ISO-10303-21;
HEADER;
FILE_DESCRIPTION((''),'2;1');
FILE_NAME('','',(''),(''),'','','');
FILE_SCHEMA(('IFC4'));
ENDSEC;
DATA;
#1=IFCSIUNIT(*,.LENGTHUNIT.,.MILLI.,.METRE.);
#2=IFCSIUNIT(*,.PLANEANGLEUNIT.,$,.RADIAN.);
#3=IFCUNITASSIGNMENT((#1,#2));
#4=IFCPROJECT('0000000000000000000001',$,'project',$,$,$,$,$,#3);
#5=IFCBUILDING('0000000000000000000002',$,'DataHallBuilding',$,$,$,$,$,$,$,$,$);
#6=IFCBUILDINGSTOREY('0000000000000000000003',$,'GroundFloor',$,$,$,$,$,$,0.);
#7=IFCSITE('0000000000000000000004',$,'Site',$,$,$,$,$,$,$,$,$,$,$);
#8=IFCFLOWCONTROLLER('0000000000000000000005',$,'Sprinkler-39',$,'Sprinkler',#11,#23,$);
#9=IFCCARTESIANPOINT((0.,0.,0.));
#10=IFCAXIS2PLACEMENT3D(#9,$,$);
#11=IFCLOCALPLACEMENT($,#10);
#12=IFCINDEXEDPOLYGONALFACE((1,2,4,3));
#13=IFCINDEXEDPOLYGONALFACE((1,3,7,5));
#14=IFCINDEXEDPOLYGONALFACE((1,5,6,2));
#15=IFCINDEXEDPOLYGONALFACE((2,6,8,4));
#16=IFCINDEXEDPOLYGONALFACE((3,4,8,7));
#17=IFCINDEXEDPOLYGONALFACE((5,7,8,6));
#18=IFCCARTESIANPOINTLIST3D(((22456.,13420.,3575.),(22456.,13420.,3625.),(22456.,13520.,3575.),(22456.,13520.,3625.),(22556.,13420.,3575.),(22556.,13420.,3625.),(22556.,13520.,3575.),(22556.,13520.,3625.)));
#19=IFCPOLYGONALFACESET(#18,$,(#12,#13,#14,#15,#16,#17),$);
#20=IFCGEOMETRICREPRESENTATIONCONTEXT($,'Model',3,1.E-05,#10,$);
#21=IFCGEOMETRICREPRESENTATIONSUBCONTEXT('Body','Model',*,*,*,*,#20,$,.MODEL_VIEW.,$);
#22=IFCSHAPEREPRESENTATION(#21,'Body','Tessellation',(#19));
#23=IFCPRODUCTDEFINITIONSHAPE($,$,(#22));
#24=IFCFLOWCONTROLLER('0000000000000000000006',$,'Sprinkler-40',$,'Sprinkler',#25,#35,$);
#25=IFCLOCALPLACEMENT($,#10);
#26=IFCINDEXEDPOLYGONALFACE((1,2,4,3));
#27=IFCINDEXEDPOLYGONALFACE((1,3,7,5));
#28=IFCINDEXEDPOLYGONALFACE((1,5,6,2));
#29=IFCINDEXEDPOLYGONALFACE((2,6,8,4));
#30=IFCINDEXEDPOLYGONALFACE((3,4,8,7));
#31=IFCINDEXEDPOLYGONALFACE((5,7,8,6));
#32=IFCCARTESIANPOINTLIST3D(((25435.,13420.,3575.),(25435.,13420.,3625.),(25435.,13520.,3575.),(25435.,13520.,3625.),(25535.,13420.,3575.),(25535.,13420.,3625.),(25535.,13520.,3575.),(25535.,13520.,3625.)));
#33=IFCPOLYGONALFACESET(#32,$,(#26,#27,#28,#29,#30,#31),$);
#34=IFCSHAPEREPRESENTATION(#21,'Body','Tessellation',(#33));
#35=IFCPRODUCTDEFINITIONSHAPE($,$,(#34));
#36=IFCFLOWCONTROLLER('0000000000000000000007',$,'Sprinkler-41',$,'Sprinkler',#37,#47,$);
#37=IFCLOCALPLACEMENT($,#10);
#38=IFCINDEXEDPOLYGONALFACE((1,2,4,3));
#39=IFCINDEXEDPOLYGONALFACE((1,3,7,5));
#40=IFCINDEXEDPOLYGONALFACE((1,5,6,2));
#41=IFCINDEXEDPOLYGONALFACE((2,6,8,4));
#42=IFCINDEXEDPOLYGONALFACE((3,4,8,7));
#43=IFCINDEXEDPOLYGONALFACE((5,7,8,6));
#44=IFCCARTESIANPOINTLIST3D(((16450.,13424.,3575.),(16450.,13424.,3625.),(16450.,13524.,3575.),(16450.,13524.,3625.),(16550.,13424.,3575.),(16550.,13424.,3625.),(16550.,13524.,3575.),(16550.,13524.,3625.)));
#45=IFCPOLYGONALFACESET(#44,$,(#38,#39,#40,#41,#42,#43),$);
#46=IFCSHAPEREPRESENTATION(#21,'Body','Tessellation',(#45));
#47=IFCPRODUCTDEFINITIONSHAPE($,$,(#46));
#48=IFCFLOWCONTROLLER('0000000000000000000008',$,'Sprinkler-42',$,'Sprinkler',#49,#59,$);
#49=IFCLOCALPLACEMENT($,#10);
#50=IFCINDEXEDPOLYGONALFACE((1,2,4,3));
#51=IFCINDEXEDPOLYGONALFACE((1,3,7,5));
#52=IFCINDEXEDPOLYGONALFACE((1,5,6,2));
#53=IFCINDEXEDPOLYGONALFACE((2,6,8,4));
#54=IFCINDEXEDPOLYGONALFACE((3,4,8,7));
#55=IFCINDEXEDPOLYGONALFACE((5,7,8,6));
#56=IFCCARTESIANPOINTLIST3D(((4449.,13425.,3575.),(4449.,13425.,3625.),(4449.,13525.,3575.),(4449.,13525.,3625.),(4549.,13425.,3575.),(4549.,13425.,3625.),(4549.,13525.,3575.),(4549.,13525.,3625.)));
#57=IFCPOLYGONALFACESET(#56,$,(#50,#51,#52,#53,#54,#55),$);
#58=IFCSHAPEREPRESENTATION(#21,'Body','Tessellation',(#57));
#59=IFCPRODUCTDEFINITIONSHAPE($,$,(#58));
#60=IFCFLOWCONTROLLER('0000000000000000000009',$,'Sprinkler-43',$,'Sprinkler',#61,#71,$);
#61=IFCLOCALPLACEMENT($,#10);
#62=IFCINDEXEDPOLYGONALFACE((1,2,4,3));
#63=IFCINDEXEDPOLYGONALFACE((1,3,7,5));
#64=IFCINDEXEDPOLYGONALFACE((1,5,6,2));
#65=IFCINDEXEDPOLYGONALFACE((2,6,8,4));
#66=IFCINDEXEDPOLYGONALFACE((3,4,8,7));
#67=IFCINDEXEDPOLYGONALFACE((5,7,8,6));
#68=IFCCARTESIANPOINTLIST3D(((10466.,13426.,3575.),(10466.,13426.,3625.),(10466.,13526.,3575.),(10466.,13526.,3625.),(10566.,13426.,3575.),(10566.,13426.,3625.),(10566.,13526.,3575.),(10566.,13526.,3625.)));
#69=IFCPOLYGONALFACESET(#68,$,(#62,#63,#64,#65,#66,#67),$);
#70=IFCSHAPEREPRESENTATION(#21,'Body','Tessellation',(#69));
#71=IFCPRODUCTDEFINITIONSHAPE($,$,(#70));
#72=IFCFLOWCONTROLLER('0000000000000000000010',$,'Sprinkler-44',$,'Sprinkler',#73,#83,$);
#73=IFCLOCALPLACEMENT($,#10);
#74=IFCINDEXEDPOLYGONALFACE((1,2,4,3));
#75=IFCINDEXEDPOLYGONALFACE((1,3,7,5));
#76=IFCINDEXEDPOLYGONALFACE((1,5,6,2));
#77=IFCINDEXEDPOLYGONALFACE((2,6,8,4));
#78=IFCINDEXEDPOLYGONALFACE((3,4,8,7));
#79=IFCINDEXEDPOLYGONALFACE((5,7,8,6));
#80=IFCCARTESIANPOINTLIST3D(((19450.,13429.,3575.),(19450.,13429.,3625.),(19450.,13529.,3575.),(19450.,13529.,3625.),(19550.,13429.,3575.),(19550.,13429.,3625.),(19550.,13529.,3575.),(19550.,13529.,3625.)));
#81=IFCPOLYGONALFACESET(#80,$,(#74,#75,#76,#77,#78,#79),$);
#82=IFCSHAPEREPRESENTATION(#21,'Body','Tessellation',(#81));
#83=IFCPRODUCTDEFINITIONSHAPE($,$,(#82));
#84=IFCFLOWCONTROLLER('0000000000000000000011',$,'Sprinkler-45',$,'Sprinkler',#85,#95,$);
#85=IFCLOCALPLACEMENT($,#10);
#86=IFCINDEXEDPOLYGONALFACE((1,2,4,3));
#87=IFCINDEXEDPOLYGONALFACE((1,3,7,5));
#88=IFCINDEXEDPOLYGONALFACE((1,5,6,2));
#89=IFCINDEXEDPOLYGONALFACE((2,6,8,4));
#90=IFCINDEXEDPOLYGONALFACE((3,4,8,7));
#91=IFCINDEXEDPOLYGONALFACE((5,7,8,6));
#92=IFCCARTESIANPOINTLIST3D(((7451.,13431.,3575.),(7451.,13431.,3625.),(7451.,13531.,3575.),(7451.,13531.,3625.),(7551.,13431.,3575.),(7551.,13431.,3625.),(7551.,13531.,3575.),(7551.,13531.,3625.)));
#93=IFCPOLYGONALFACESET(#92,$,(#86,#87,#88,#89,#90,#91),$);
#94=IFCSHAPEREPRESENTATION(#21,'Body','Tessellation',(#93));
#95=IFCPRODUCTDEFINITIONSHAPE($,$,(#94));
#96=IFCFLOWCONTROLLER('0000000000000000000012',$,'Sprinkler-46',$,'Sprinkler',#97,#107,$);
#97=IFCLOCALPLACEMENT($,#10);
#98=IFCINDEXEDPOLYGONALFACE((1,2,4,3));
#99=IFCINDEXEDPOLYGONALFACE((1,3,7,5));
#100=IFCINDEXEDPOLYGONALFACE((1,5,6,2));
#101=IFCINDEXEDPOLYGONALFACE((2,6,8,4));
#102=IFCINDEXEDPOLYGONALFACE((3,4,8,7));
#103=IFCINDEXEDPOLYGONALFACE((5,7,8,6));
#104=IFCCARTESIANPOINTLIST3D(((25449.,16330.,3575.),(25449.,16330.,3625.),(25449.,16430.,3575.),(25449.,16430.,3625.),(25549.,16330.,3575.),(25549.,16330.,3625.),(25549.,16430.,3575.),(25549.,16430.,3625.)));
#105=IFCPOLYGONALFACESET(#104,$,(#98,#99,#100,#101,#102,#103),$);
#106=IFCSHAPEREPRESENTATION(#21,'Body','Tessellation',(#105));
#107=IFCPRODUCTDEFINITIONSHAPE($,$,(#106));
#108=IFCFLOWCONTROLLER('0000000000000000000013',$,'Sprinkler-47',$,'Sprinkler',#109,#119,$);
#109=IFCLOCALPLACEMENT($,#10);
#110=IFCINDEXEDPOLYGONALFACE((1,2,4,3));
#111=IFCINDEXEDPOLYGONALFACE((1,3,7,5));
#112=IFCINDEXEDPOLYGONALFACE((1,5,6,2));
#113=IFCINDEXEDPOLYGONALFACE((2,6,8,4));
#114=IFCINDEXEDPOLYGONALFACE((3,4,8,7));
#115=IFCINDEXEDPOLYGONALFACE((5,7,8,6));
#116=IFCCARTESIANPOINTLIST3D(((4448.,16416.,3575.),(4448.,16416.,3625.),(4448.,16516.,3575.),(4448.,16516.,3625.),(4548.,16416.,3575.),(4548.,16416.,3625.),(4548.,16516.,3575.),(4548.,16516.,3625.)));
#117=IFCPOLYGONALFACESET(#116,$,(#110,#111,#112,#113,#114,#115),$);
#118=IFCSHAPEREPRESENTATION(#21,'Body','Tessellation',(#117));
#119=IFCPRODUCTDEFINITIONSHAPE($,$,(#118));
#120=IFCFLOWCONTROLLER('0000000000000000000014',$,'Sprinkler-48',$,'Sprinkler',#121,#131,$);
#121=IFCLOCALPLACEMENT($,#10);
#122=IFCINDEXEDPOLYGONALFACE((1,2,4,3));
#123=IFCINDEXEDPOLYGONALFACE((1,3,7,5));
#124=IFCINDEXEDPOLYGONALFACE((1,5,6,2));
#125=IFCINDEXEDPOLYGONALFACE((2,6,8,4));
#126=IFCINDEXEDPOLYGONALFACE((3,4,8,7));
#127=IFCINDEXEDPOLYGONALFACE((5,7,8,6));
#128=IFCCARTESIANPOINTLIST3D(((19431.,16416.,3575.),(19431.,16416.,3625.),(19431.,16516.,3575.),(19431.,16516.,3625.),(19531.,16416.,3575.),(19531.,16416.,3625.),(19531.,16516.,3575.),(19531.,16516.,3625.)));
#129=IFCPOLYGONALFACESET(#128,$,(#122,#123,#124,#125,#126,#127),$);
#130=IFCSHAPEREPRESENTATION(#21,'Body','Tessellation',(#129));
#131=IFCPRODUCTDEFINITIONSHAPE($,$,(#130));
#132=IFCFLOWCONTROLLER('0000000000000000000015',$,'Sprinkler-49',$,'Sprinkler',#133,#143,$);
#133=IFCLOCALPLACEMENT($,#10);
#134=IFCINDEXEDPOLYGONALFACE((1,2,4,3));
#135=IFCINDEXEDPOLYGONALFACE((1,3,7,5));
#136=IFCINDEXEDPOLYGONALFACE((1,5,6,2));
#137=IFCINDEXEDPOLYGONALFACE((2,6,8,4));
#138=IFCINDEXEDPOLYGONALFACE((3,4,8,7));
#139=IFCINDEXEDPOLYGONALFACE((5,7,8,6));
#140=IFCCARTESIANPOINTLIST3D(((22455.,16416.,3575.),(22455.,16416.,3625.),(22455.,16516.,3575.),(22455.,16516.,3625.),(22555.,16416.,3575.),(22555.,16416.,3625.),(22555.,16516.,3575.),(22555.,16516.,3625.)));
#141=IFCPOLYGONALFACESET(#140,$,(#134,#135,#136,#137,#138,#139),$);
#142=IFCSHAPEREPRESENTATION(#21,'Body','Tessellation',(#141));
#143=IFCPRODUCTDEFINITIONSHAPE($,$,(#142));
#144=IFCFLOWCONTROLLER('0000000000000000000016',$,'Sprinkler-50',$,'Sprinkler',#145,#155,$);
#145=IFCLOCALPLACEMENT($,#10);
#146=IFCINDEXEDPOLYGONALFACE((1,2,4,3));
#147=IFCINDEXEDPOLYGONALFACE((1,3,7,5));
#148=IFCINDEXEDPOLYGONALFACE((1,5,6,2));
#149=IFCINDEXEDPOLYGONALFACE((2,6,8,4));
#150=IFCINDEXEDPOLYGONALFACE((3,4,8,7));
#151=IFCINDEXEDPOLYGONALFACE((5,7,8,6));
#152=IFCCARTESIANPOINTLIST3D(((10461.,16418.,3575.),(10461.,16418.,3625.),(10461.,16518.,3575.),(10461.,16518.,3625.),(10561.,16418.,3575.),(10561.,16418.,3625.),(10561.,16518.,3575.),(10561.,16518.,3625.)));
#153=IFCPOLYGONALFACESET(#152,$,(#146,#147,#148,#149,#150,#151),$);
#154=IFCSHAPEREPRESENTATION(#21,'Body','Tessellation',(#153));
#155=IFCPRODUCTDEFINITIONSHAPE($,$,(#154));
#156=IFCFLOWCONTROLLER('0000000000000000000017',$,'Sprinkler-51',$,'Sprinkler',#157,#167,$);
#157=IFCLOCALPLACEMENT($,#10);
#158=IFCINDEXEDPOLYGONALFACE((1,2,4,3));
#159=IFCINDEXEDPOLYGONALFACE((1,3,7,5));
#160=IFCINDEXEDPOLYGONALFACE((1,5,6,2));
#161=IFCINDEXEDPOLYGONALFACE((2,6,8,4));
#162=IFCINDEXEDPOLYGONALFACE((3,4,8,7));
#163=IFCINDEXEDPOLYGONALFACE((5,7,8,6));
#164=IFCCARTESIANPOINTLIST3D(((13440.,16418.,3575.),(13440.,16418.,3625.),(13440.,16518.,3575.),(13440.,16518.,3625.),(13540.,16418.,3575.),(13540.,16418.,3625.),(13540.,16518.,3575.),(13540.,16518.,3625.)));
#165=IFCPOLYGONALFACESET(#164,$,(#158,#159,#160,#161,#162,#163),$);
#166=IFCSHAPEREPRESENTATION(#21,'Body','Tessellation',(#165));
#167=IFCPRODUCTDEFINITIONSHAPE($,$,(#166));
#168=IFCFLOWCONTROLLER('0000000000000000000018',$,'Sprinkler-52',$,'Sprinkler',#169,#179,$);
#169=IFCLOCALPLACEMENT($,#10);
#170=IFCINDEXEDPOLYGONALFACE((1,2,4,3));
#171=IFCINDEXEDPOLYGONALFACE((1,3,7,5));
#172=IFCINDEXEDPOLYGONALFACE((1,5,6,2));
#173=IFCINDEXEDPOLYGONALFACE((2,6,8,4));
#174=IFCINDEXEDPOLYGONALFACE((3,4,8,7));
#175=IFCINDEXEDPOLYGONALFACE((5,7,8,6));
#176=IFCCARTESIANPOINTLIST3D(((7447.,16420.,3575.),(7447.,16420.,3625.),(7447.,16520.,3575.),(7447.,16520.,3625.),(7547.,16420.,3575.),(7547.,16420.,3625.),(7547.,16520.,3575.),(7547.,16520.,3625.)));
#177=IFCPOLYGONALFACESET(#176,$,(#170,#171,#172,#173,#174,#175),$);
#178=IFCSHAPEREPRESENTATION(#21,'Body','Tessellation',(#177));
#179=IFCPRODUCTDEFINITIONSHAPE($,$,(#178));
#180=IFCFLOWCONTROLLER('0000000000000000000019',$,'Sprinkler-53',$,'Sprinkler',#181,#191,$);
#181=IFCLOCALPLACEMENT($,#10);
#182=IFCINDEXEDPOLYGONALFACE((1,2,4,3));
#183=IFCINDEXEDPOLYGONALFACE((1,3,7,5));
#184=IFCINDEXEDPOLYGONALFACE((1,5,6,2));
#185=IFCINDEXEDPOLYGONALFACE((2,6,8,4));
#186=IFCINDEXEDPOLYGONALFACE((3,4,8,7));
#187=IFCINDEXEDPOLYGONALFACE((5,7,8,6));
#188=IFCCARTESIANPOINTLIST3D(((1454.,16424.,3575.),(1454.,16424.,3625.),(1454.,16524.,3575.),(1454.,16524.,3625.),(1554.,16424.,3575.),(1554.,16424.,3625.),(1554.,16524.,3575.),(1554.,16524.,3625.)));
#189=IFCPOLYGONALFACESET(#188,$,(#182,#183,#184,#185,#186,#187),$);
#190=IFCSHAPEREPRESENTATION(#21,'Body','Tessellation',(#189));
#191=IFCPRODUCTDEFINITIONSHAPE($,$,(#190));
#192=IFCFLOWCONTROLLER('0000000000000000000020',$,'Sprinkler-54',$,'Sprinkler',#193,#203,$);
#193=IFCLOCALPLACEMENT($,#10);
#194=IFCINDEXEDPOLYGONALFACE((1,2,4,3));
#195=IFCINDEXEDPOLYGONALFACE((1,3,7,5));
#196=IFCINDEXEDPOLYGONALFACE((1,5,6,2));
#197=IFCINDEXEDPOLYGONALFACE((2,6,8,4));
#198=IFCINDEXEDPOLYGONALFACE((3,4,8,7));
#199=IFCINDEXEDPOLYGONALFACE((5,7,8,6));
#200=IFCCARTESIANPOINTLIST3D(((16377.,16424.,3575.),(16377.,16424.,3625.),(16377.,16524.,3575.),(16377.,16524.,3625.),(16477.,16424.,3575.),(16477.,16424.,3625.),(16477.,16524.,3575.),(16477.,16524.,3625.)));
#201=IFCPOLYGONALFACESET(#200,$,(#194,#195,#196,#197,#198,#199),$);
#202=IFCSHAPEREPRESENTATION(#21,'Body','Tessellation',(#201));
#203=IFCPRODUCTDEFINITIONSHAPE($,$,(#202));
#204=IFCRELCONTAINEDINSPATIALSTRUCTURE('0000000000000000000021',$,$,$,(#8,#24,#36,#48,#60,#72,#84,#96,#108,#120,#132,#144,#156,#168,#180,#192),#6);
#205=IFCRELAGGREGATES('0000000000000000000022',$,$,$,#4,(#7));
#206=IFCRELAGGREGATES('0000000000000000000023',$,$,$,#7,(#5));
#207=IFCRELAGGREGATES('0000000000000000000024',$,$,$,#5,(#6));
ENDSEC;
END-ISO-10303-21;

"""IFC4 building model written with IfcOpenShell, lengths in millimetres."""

from ifc_helpers import new_model, si_unit, frame, origin, place, context, subcontext, project, spatial, rectangle, extrude, element, save


model = new_model("IFC4")

# Units and contexts
model_context = context("Model", 3, precision=1e-05, world=origin())
body_context = subcontext(model_context, "Body", "Model", "MODEL_VIEW")
ifc_project = project(units=[si_unit("LENGTHUNIT", "METRE", prefix="MILLI"), si_unit("PLANEANGLEUNIT", "RADIAN")])

# Site, building, storey
site = spatial("IfcSite", under=ifc_project, Name="Site")
building = spatial("IfcBuilding", under=site, Name="DataHallBuilding")
storey = spatial("IfcBuildingStorey", under=building, Name="GroundFloor", Elevation=0.0)

# Flow controllers
flow_controller_1_placement = place(None, origin())
element("IfcFlowController", 1, at=flow_controller_1_placement, inside=storey, Name="Sprinkler-39", ObjectType="Sprinkler", context=body_context, shape_type="SweptSolid", body=[
    extrude(rectangle(XDim=100.0, YDim=100.0), frame((22506.0, 13470.0, 3575.0), z_axis=(0.0, 0.0, 1.0), x_axis=(1.0, 0.0, 0.0)), (0.0, 0.0, 1.0), 50.0),
])
flow_controller_2_placement = place(None, origin())
element("IfcFlowController", 2, at=flow_controller_2_placement, inside=storey, Name="Sprinkler-40", ObjectType="Sprinkler", context=body_context, shape_type="SweptSolid", body=[
    extrude(rectangle(XDim=100.0, YDim=100.0), frame((25485.0, 13470.0, 3575.0), z_axis=(0.0, 0.0, 1.0), x_axis=(1.0, 0.0, 0.0)), (0.0, 0.0, 1.0), 50.0),
])
flow_controller_3_placement = place(None, origin())
element("IfcFlowController", 3, at=flow_controller_3_placement, inside=storey, Name="Sprinkler-41", ObjectType="Sprinkler", context=body_context, shape_type="SweptSolid", body=[
    extrude(rectangle(XDim=100.0, YDim=100.0), frame((16500.0, 13474.0, 3575.0), z_axis=(0.0, 0.0, 1.0), x_axis=(1.0, 0.0, 0.0)), (0.0, 0.0, 1.0), 50.0),
])
flow_controller_4_placement = place(None, origin())
element("IfcFlowController", 4, at=flow_controller_4_placement, inside=storey, Name="Sprinkler-42", ObjectType="Sprinkler", context=body_context, shape_type="SweptSolid", body=[
    extrude(rectangle(XDim=100.0, YDim=100.0), frame((4499.0, 13475.0, 3575.0), z_axis=(0.0, 0.0, 1.0), x_axis=(1.0, 0.0, 0.0)), (0.0, 0.0, 1.0), 50.0),
])
flow_controller_5_placement = place(None, origin())
element("IfcFlowController", 5, at=flow_controller_5_placement, inside=storey, Name="Sprinkler-43", ObjectType="Sprinkler", context=body_context, shape_type="SweptSolid", body=[
    extrude(rectangle(XDim=100.0, YDim=100.0), frame((10516.0, 13476.0, 3575.0), z_axis=(0.0, 0.0, 1.0), x_axis=(1.0, 0.0, 0.0)), (0.0, 0.0, 1.0), 50.0),
])
flow_controller_6_placement = place(None, origin())
element("IfcFlowController", 6, at=flow_controller_6_placement, inside=storey, Name="Sprinkler-44", ObjectType="Sprinkler", context=body_context, shape_type="SweptSolid", body=[
    extrude(rectangle(XDim=100.0, YDim=100.0), frame((19500.0, 13479.0, 3575.0), z_axis=(0.0, 0.0, 1.0), x_axis=(1.0, 0.0, 0.0)), (0.0, 0.0, 1.0), 50.0),
])
flow_controller_7_placement = place(None, origin())
element("IfcFlowController", 7, at=flow_controller_7_placement, inside=storey, Name="Sprinkler-45", ObjectType="Sprinkler", context=body_context, shape_type="SweptSolid", body=[
    extrude(rectangle(XDim=100.0, YDim=100.0), frame((7501.0, 13481.0, 3575.0), z_axis=(0.0, 0.0, 1.0), x_axis=(1.0, 0.0, 0.0)), (0.0, 0.0, 1.0), 50.0),
])
flow_controller_8_placement = place(None, origin())
element("IfcFlowController", 8, at=flow_controller_8_placement, inside=storey, Name="Sprinkler-46", ObjectType="Sprinkler", context=body_context, shape_type="SweptSolid", body=[
    extrude(rectangle(XDim=100.0, YDim=100.0), frame((25499.0, 16380.0, 3575.0), z_axis=(0.0, 0.0, 1.0), x_axis=(1.0, 0.0, 0.0)), (0.0, 0.0, 1.0), 50.0),
])
flow_controller_9_placement = place(None, origin())
element("IfcFlowController", 9, at=flow_controller_9_placement, inside=storey, Name="Sprinkler-47", ObjectType="Sprinkler", context=body_context, shape_type="SweptSolid", body=[
    extrude(rectangle(XDim=100.0, YDim=100.0), frame((4498.0, 16466.0, 3575.0), z_axis=(0.0, 0.0, 1.0), x_axis=(1.0, 0.0, 0.0)), (0.0, 0.0, 1.0), 50.0),
])
flow_controller_10_placement = place(None, origin())
element("IfcFlowController", 10, at=flow_controller_10_placement, inside=storey, Name="Sprinkler-48", ObjectType="Sprinkler", context=body_context, shape_type="SweptSolid", body=[
    extrude(rectangle(XDim=100.0, YDim=100.0), frame((19481.0, 16466.0, 3575.0), z_axis=(0.0, 0.0, 1.0), x_axis=(1.0, 0.0, 0.0)), (0.0, 0.0, 1.0), 50.0),
])
flow_controller_11_placement = place(None, origin())
element("IfcFlowController", 11, at=flow_controller_11_placement, inside=storey, Name="Sprinkler-49", ObjectType="Sprinkler", context=body_context, shape_type="SweptSolid", body=[
    extrude(rectangle(XDim=100.0, YDim=100.0), frame((22505.0, 16466.0, 3575.0), z_axis=(0.0, 0.0, 1.0), x_axis=(1.0, 0.0, 0.0)), (0.0, 0.0, 1.0), 50.0),
])
flow_controller_12_placement = place(None, origin())
element("IfcFlowController", 12, at=flow_controller_12_placement, inside=storey, Name="Sprinkler-50", ObjectType="Sprinkler", context=body_context, shape_type="SweptSolid", body=[
    extrude(rectangle(XDim=100.0, YDim=100.0), frame((10511.0, 16468.0, 3575.0), z_axis=(0.0, 0.0, 1.0), x_axis=(1.0, 0.0, 0.0)), (0.0, 0.0, 1.0), 50.0),
])
flow_controller_13_placement = place(None, origin())
element("IfcFlowController", 13, at=flow_controller_13_placement, inside=storey, Name="Sprinkler-51", ObjectType="Sprinkler", context=body_context, shape_type="SweptSolid", body=[
    extrude(rectangle(XDim=100.0, YDim=100.0), frame((13490.0, 16468.0, 3575.0), z_axis=(0.0, 0.0, 1.0), x_axis=(1.0, 0.0, 0.0)), (0.0, 0.0, 1.0), 50.0),
])
flow_controller_14_placement = place(None, origin())
element("IfcFlowController", 14, at=flow_controller_14_placement, inside=storey, Name="Sprinkler-52", ObjectType="Sprinkler", context=body_context, shape_type="SweptSolid", body=[
    extrude(rectangle(XDim=100.0, YDim=100.0), frame((7497.0, 16470.0, 3575.0), z_axis=(0.0, 0.0, 1.0), x_axis=(1.0, 0.0, 0.0)), (0.0, 0.0, 1.0), 50.0),
])
flow_controller_15_placement = place(None, origin())
element("IfcFlowController", 15, at=flow_controller_15_placement, inside=storey, Name="Sprinkler-53", ObjectType="Sprinkler", context=body_context, shape_type="SweptSolid", body=[
    extrude(rectangle(XDim=100.0, YDim=100.0), frame((1504.0, 16474.0, 3575.0), z_axis=(0.0, 0.0, 1.0), x_axis=(1.0, 0.0, 0.0)), (0.0, 0.0, 1.0), 50.0),
])
flow_controller_16_placement = place(None, origin())
element("IfcFlowController", 16, at=flow_controller_16_placement, inside=storey, Name="Sprinkler-54", ObjectType="Sprinkler", context=body_context, shape_type="SweptSolid", body=[
    extrude(rectangle(XDim=100.0, YDim=100.0), frame((16427.0, 16474.0, 3575.0), z_axis=(0.0, 0.0, 1.0), x_axis=(1.0, 0.0, 0.0)), (0.0, 0.0, 1.0), 50.0),
])

save(model, "model.ifc")
